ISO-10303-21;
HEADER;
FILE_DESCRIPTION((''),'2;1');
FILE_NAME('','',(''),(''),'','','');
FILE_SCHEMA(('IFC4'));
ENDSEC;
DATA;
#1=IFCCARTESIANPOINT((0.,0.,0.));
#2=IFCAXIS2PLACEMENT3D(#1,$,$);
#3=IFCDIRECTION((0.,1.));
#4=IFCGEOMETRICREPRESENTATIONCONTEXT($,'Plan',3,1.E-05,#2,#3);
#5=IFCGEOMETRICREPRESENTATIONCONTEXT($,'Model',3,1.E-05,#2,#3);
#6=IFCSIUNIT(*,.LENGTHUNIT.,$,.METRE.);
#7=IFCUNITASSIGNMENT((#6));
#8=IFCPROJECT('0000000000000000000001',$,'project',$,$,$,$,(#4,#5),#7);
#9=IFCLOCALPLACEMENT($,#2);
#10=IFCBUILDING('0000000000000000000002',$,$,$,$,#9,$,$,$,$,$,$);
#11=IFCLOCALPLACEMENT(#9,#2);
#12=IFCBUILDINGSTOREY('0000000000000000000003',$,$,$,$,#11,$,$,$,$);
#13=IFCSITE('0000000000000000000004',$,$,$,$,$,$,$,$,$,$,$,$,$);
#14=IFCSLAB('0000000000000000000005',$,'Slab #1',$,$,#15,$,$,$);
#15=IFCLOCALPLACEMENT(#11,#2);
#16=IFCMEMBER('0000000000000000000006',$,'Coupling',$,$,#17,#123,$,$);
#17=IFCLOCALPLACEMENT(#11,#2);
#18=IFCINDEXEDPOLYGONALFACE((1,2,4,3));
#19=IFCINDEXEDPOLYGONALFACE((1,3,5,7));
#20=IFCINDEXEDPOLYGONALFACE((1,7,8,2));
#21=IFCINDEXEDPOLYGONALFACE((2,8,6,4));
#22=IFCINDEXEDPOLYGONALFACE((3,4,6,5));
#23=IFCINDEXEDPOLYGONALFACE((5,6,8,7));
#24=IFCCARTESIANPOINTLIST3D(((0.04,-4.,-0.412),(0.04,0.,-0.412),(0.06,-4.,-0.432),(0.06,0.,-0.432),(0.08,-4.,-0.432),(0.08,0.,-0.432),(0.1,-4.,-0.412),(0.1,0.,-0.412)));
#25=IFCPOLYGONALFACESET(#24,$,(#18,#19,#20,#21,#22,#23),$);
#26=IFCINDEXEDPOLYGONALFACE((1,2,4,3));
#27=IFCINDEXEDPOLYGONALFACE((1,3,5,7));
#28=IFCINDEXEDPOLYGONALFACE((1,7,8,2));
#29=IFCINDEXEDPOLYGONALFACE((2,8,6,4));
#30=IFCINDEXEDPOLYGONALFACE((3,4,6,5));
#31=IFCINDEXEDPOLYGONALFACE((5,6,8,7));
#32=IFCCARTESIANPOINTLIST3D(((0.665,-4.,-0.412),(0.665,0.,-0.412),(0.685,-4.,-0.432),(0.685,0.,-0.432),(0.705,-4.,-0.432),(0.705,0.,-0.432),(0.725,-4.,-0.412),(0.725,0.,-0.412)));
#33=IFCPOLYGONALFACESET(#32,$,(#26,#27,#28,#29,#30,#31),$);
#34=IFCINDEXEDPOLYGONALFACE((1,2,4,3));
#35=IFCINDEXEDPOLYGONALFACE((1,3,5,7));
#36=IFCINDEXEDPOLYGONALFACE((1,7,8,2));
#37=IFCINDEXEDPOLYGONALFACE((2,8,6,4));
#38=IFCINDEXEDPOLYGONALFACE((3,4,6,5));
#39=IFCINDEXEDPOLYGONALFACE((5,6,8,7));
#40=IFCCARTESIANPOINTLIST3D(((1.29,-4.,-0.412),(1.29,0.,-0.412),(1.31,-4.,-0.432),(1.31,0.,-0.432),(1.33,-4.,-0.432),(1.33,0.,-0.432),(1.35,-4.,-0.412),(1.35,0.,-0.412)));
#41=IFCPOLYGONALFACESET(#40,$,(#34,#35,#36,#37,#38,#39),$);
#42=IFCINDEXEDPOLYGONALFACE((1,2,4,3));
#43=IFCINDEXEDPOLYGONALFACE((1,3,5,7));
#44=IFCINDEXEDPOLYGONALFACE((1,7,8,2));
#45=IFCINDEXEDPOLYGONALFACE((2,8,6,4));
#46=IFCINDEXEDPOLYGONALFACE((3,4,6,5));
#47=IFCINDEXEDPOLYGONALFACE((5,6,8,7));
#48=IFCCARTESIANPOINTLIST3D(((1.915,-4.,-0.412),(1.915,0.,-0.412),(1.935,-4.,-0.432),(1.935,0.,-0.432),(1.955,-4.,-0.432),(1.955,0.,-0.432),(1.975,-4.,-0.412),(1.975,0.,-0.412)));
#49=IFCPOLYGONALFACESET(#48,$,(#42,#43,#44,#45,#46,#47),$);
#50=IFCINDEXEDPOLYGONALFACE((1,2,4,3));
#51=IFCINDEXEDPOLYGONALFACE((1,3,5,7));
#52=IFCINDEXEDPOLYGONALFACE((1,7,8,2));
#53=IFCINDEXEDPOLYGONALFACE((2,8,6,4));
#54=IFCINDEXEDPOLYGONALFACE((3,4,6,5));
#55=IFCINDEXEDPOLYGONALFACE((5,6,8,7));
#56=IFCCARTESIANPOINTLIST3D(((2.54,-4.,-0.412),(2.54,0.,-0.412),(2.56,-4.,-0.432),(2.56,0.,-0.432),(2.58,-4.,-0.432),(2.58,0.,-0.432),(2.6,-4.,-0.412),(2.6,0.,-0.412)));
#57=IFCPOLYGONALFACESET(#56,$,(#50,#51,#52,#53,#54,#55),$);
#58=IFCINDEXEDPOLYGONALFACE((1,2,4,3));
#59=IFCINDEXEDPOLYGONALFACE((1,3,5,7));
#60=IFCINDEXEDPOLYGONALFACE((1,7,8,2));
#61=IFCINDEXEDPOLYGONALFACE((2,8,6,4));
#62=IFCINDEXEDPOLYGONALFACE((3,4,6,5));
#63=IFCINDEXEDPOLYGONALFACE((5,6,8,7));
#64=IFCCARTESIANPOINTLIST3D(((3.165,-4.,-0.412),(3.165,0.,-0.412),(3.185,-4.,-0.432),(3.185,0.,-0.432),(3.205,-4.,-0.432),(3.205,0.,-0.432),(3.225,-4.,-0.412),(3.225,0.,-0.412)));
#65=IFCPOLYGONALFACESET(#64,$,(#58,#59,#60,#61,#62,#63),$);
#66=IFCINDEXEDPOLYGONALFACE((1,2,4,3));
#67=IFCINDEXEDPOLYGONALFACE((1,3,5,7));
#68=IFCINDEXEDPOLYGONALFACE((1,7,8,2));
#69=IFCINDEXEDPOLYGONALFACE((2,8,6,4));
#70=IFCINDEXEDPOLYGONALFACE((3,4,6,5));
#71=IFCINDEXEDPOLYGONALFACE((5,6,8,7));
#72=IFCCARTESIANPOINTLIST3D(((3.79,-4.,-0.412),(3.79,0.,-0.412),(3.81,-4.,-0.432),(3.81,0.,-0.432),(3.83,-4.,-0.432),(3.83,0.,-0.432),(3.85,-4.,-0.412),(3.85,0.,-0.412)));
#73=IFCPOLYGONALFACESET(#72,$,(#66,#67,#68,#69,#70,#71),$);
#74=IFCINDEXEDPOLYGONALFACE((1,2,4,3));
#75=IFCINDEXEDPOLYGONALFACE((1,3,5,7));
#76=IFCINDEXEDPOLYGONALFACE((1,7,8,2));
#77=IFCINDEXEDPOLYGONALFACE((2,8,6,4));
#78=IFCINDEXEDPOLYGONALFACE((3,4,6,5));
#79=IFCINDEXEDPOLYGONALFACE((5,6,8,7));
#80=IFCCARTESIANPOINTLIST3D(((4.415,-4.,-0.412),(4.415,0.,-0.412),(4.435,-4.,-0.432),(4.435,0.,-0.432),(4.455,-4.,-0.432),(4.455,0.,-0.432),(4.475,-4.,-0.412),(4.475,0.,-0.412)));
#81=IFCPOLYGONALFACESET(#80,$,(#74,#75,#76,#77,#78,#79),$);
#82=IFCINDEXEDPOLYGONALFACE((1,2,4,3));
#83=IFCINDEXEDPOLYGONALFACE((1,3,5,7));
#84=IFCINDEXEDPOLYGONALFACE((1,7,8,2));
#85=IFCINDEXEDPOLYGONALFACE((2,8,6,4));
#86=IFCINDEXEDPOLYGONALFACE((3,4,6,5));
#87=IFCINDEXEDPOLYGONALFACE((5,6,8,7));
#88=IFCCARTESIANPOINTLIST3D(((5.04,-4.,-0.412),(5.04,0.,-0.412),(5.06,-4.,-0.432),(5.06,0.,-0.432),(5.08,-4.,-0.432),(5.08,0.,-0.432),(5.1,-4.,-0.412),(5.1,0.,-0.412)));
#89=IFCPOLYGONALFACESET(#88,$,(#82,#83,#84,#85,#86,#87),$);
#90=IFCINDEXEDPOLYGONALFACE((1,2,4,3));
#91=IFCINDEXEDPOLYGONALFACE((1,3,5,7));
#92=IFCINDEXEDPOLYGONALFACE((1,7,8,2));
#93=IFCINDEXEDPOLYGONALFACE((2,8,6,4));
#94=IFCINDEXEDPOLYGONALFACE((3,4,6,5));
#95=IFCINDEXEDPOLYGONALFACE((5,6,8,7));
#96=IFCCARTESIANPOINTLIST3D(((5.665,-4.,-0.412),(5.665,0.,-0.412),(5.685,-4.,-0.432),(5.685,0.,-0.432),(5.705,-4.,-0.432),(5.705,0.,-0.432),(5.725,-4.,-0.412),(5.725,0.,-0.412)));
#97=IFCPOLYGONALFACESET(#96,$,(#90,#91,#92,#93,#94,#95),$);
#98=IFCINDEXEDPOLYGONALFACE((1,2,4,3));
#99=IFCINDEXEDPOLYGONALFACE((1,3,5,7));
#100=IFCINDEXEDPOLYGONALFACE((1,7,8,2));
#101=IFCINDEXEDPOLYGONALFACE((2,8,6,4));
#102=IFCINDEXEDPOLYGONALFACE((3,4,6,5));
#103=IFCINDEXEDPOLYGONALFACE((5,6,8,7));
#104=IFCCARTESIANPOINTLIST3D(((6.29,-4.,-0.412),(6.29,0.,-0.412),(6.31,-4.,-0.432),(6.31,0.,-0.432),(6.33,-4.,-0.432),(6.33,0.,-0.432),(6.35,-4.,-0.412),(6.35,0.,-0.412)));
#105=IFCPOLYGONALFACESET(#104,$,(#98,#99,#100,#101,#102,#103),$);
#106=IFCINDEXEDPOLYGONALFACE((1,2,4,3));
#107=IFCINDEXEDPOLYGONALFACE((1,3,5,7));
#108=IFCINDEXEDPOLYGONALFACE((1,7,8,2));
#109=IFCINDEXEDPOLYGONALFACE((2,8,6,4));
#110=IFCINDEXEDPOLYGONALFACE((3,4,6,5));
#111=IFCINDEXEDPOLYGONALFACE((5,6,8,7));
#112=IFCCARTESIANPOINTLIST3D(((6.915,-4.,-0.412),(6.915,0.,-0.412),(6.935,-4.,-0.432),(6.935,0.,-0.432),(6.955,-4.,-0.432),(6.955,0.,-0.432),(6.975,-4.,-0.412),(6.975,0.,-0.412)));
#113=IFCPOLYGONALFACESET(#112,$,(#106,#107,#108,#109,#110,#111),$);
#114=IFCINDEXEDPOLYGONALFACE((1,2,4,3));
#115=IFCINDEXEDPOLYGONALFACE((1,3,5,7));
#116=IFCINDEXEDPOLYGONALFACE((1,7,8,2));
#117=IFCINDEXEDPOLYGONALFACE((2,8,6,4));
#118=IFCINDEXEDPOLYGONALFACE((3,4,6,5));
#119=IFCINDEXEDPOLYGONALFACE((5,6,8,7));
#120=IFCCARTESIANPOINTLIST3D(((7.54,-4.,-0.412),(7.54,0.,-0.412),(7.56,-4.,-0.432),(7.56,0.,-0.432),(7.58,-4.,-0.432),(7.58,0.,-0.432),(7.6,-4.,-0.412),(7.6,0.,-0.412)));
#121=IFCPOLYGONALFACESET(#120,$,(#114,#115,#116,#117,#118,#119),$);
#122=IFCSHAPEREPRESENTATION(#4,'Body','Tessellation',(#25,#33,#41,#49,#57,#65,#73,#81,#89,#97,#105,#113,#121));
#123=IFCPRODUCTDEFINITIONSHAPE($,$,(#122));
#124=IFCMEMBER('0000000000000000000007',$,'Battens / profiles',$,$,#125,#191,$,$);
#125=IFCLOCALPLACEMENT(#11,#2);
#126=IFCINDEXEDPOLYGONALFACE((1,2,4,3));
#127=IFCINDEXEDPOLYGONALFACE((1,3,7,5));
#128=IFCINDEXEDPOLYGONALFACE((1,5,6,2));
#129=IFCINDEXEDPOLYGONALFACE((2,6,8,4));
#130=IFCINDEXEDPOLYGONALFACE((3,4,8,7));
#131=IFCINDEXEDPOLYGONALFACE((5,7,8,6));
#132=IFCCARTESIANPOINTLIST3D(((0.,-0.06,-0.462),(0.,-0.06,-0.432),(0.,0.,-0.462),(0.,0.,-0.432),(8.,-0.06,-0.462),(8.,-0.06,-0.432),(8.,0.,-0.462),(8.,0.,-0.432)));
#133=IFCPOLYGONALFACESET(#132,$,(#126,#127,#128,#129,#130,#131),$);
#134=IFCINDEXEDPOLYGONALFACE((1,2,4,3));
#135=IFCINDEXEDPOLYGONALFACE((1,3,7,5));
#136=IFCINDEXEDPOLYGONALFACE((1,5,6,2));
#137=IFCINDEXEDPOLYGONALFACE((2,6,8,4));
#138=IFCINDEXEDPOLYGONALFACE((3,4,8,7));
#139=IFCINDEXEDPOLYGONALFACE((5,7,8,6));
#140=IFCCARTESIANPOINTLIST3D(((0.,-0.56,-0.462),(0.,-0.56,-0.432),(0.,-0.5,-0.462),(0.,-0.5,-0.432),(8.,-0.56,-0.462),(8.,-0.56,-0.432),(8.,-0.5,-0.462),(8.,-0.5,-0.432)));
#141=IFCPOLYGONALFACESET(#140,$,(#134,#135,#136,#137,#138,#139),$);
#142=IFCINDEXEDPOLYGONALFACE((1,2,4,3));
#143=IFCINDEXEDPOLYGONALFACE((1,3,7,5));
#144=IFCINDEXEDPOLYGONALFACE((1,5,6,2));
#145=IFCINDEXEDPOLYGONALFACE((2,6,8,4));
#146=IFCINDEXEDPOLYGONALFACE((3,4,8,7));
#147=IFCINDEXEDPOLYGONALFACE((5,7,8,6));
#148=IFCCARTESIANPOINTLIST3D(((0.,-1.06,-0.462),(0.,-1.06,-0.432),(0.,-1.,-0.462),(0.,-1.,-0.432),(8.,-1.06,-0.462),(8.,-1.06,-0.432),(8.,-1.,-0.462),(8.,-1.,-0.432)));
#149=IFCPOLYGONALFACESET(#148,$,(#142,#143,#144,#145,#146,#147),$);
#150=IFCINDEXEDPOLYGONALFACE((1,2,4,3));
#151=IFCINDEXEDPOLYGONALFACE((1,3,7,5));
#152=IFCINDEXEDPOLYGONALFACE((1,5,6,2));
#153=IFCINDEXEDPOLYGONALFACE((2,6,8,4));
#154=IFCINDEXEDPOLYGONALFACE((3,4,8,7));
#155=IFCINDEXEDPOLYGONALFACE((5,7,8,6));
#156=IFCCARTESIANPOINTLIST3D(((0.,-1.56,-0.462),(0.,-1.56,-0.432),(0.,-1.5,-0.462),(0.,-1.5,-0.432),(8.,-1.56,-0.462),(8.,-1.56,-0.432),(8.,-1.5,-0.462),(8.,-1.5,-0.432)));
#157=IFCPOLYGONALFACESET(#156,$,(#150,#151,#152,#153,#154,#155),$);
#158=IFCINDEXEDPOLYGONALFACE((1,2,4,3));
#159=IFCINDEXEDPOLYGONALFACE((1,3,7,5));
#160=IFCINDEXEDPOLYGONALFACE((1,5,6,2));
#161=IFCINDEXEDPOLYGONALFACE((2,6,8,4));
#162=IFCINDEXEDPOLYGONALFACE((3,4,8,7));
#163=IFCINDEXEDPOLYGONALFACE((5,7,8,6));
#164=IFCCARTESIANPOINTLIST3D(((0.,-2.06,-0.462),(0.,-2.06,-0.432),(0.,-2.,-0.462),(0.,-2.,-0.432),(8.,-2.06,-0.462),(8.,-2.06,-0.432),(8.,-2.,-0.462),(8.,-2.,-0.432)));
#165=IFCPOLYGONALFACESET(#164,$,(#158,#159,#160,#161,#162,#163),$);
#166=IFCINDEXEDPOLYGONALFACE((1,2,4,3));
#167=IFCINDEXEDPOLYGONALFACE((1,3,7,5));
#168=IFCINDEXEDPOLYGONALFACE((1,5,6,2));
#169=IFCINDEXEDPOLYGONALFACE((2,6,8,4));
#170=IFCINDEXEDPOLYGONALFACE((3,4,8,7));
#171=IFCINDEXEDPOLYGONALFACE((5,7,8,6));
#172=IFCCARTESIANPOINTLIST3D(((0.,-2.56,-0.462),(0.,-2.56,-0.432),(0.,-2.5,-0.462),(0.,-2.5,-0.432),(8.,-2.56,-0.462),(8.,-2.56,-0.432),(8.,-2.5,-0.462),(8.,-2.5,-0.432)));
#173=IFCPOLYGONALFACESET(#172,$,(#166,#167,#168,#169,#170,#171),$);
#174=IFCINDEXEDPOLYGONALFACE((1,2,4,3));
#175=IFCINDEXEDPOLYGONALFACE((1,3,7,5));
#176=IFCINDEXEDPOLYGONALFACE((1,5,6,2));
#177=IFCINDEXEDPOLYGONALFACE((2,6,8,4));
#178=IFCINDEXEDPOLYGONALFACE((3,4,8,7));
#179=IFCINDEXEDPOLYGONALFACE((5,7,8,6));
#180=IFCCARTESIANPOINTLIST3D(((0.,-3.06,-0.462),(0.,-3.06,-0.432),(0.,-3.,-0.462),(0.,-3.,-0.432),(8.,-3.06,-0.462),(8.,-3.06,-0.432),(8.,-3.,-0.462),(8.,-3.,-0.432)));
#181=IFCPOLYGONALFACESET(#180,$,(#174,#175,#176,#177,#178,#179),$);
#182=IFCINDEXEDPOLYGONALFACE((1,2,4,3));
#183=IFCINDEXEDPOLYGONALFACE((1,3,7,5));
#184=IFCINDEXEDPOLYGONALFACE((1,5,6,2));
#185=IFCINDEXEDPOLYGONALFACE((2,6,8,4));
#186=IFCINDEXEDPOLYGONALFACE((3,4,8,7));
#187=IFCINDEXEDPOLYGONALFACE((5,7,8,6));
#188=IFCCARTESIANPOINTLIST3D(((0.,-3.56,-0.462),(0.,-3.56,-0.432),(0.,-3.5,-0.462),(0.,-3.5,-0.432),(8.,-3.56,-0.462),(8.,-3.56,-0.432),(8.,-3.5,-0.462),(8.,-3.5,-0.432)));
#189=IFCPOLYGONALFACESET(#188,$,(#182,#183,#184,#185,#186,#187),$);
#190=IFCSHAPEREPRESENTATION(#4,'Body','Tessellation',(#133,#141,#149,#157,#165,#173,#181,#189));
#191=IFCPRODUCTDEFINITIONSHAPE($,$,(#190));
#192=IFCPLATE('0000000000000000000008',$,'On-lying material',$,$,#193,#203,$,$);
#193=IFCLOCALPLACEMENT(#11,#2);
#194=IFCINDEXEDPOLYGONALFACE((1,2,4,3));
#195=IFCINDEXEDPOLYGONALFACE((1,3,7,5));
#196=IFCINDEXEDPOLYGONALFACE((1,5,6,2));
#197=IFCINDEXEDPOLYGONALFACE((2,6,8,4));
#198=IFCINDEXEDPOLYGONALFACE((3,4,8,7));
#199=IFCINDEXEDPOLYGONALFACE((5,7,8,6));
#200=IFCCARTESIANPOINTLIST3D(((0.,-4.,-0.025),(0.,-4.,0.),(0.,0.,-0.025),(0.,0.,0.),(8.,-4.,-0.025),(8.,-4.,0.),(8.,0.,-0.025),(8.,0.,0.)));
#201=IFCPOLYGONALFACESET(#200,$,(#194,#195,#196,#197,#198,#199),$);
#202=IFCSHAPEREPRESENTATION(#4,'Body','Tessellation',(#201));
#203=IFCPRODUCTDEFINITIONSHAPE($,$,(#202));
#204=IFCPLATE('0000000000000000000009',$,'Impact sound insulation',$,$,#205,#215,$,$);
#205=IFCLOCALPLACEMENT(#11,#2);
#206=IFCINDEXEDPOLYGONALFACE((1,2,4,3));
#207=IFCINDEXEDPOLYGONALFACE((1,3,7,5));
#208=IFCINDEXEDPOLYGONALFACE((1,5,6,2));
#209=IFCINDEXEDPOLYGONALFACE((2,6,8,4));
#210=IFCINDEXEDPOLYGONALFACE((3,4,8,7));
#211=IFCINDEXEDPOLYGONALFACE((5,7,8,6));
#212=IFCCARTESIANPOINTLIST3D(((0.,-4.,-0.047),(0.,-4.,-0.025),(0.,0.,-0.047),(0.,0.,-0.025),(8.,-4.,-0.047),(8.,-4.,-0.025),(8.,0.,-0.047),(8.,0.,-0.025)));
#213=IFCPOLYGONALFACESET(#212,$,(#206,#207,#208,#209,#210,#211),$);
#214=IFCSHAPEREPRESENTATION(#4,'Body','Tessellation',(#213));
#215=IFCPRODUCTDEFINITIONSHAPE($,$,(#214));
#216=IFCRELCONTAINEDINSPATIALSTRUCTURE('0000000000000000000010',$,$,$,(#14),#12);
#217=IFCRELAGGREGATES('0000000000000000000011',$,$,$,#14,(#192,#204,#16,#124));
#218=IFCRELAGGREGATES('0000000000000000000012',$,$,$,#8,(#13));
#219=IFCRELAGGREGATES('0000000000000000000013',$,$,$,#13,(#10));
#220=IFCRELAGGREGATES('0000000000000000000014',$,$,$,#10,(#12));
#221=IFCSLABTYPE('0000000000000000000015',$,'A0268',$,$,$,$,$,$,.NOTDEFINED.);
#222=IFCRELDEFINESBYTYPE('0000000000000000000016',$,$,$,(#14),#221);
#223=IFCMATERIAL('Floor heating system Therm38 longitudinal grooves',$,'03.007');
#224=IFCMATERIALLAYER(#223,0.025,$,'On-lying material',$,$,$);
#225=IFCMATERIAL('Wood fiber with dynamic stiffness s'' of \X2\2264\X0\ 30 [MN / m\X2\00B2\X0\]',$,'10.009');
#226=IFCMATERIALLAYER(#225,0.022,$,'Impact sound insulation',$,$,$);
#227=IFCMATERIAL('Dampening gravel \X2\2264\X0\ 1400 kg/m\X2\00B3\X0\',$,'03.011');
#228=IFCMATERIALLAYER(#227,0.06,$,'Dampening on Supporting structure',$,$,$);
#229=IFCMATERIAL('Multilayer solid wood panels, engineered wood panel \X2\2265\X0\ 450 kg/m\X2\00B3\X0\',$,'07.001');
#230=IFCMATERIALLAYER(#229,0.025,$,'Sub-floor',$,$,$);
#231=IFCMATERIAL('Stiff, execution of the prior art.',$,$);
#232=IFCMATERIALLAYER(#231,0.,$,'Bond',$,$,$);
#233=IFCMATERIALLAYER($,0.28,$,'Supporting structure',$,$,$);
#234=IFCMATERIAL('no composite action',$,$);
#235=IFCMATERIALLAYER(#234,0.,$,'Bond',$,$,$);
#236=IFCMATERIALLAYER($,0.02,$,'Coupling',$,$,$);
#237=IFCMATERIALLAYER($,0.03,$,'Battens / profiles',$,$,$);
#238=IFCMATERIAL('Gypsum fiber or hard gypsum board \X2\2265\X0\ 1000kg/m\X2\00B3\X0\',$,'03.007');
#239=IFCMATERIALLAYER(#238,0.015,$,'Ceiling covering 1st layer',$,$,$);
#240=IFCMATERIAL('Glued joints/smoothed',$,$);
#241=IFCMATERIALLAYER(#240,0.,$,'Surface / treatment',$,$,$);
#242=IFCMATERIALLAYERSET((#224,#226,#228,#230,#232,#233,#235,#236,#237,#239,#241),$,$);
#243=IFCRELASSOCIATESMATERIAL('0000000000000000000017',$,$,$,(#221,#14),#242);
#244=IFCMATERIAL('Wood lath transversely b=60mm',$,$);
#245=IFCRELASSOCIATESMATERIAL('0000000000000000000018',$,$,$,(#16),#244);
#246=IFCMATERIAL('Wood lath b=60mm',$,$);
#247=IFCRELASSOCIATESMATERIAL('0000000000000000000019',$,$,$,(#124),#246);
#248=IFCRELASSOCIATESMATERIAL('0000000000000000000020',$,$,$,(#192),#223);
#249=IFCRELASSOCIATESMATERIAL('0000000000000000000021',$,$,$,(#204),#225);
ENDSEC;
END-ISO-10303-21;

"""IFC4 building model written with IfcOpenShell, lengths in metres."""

from ifc_helpers import new_model, si_unit, direction, frame, frame_2d, origin, origin_with_axes, place, context, project, spatial, polyline, rectangle, outline, extrude, material, layer, layer_set, type_object, element, aggregate, save


model = new_model("IFC4")

# Units and contexts
plan_context = context("Plan", 3, precision=1e-05, world=origin(), true_north=direction((0.0, 1.0)))
model_context = context("Model", 3, precision=1e-05, world=origin(), true_north=direction((0.0, 1.0)))
ifc_project = project(units=[si_unit("LENGTHUNIT", "METRE")], contexts=[plan_context, model_context])

# Site, building, storey
site = spatial("IfcSite", under=ifc_project)
building_placement = place(None, origin())
building = spatial("IfcBuilding", under=site, at=building_placement)
storey_placement = place(building_placement, origin())
storey = spatial("IfcBuildingStorey", under=building, at=storey_placement)

# Slab, members, plates
ifc_material_1 = material(Name="Floor heating system Therm38 longitudinal grooves", Category="03.007")
ifc_layer_1 = layer(ifc_material_1, 0.025, Name="On-lying material")
ifc_material_2 = material(Name="Wood fiber with dynamic stiffness s' of ≤ 30 [MN / m²]", Category="10.009")
ifc_layer_2 = layer(ifc_material_2, 0.022, Name="Impact sound insulation")
ifc_material_3 = material(Name="Dampening gravel ≤ 1400 kg/m³", Category="03.011")
ifc_layer_3 = layer(ifc_material_3, 0.06, Name="Dampening on Supporting structure")
ifc_material_4 = material(Name="Multilayer solid wood panels, engineered wood panel ≥ 450 kg/m³", Category="07.001")
ifc_layer_4 = layer(ifc_material_4, 0.025, Name="Sub-floor")
ifc_material_5 = material(Name="Stiff, execution of the prior art.")
ifc_layer_5 = layer(ifc_material_5, 0.0, Name="Bond")
ifc_layer_6 = layer(None, 0.28, Name="Supporting structure")
ifc_material_6 = material(Name="no composite action")
ifc_layer_7 = layer(ifc_material_6, 0.0, Name="Bond")
ifc_layer_8 = layer(None, 0.02, Name="Coupling")
ifc_layer_9 = layer(None, 0.03, Name="Battens / profiles")
ifc_material_7 = material(Name="Gypsum fiber or hard gypsum board ≥ 1000kg/m³", Category="03.007")
ifc_layer_10 = layer(ifc_material_7, 0.015, Name="Ceiling covering 1st layer")
ifc_material_8 = material(Name="Glued joints/smoothed")
ifc_layer_11 = layer(ifc_material_8, 0.0, Name="Surface / treatment")
ifc_layer_set = layer_set([ifc_layer_1, ifc_layer_2, ifc_layer_3, ifc_layer_4, ifc_layer_5, ifc_layer_6, ifc_layer_7, ifc_layer_8, ifc_layer_9, ifc_layer_10, ifc_layer_11])
slab_type = type_object("IfcSlabType", Name="A0268", PredefinedType="NOTDEFINED", material=ifc_layer_set)
slab_placement = place(None, frame((0.0, 0.0, 0.0), z_axis=(0.0, 0.0, -1.0), x_axis=(1.0, 0.0, 0.0)))
slab = element("IfcSlab", 1, at=slab_placement, inside=storey, type_object=slab_type, material=ifc_layer_set, Name="Slab #1")
ifc_material_9 = material(Name="Wood lath transversely b=60mm")
member_1_placement = place(slab_placement, origin())
member_1 = element("IfcMember", 2, at=member_1_placement, material=ifc_material_9, Name="Coupling", context=plan_context, shape_type="SweptSolid", body=[
    extrude(outline(polyline([(0.0, 0.0), (0.06, 0.0), (0.04, 0.02), (0.02, 0.02), (0.0, 0.0)])), frame((0.04, 4.0, 0.412), z_axis=(0.0, -1.0, 0.0), x_axis=(1.0, 0.0, 0.0)), (0.0, 0.0, 1.0), 4.0),
    extrude(outline(polyline([(0.0, 0.0), (0.06, 0.0), (0.04, 0.02), (0.02, 0.02), (0.0, 0.0)])), frame((0.665, 4.0, 0.412), z_axis=(0.0, -1.0, 0.0), x_axis=(1.0, 0.0, 0.0)), (0.0, 0.0, 1.0), 4.0),
    extrude(outline(polyline([(0.0, 0.0), (0.06, 0.0), (0.04, 0.02), (0.02, 0.02), (0.0, 0.0)])), frame((1.29, 4.0, 0.412), z_axis=(0.0, -1.0, 0.0), x_axis=(1.0, 0.0, 0.0)), (0.0, 0.0, 1.0), 4.0),
    extrude(outline(polyline([(0.0, 0.0), (0.06, 0.0), (0.04, 0.02), (0.02, 0.02), (0.0, 0.0)])), frame((1.915, 4.0, 0.412), z_axis=(0.0, -1.0, 0.0), x_axis=(1.0, 0.0, 0.0)), (0.0, 0.0, 1.0), 4.0),
    extrude(outline(polyline([(0.0, 0.0), (0.06, 0.0), (0.04, 0.02), (0.02, 0.02), (0.0, 0.0)])), frame((2.54, 4.0, 0.412), z_axis=(0.0, -1.0, 0.0), x_axis=(1.0, 0.0, 0.0)), (0.0, 0.0, 1.0), 4.0),
    extrude(outline(polyline([(0.0, 0.0), (0.06, 0.0), (0.04, 0.02), (0.02, 0.02), (0.0, 0.0)])), frame((3.165, 4.0, 0.412), z_axis=(0.0, -1.0, 0.0), x_axis=(1.0, 0.0, 0.0)), (0.0, 0.0, 1.0), 4.0),
    extrude(outline(polyline([(0.0, 0.0), (0.06, 0.0), (0.04, 0.02), (0.02, 0.02), (0.0, 0.0)])), frame((3.79, 4.0, 0.412), z_axis=(0.0, -1.0, 0.0), x_axis=(1.0, 0.0, 0.0)), (0.0, 0.0, 1.0), 4.0),
    extrude(outline(polyline([(0.0, 0.0), (0.06, 0.0), (0.04, 0.02), (0.02, 0.02), (0.0, 0.0)])), frame((4.415, 4.0, 0.412), z_axis=(0.0, -1.0, 0.0), x_axis=(1.0, 0.0, 0.0)), (0.0, 0.0, 1.0), 4.0),
    extrude(outline(polyline([(0.0, 0.0), (0.06, 0.0), (0.04, 0.02), (0.02, 0.02), (0.0, 0.0)])), frame((5.04, 4.0, 0.412), z_axis=(0.0, -1.0, 0.0), x_axis=(1.0, 0.0, 0.0)), (0.0, 0.0, 1.0), 4.0),
    extrude(outline(polyline([(0.0, 0.0), (0.06, 0.0), (0.04, 0.02), (0.02, 0.02), (0.0, 0.0)])), frame((5.665, 4.0, 0.412), z_axis=(0.0, -1.0, 0.0), x_axis=(1.0, 0.0, 0.0)), (0.0, 0.0, 1.0), 4.0),
    extrude(outline(polyline([(0.0, 0.0), (0.06, 0.0), (0.04, 0.02), (0.02, 0.02), (0.0, 0.0)])), frame((6.29, 4.0, 0.412), z_axis=(0.0, -1.0, 0.0), x_axis=(1.0, 0.0, 0.0)), (0.0, 0.0, 1.0), 4.0),
    extrude(outline(polyline([(0.0, 0.0), (0.06, 0.0), (0.04, 0.02), (0.02, 0.02), (0.0, 0.0)])), frame((6.915, 4.0, 0.412), z_axis=(0.0, -1.0, 0.0), x_axis=(1.0, 0.0, 0.0)), (0.0, 0.0, 1.0), 4.0),
    extrude(outline(polyline([(0.0, 0.0), (0.06, 0.0), (0.04, 0.02), (0.02, 0.02), (0.0, 0.0)])), frame((7.54, 4.0, 0.412), z_axis=(0.0, -1.0, 0.0), x_axis=(1.0, 0.0, 0.0)), (0.0, 0.0, 1.0), 4.0),
])
ifc_material_10 = material(Name="Wood lath b=60mm")
member_2_placement = place(slab_placement, origin())
member_2 = element("IfcMember", 3, at=member_2_placement, material=ifc_material_10, Name="Battens / profiles", context=plan_context, shape_type="SweptSolid", body=[
    extrude(rectangle(XDim=0.06, YDim=0.03, at=frame_2d((0.03, 0.015), x_axis=(1.0, 0.0))), frame((0.0, 0.0, 0.432), z_axis=(1.0, 0.0, 0.0), x_axis=(0.0, 1.0, 0.0)), (0.0, 0.0, 1.0), 8.0),
    extrude(rectangle(XDim=0.06, YDim=0.03, at=frame_2d((0.03, 0.015), x_axis=(1.0, 0.0))), frame((0.0, 0.5, 0.432), z_axis=(1.0, 0.0, 0.0), x_axis=(0.0, 1.0, 0.0)), (0.0, 0.0, 1.0), 8.0),
    extrude(rectangle(XDim=0.06, YDim=0.03, at=frame_2d((0.03, 0.015), x_axis=(1.0, 0.0))), frame((0.0, 1.0, 0.432), z_axis=(1.0, 0.0, 0.0), x_axis=(0.0, 1.0, 0.0)), (0.0, 0.0, 1.0), 8.0),
    extrude(rectangle(XDim=0.06, YDim=0.03, at=frame_2d((0.03, 0.015), x_axis=(1.0, 0.0))), frame((0.0, 1.5, 0.432), z_axis=(1.0, 0.0, 0.0), x_axis=(0.0, 1.0, 0.0)), (0.0, 0.0, 1.0), 8.0),
    extrude(rectangle(XDim=0.06, YDim=0.03, at=frame_2d((0.03, 0.015), x_axis=(1.0, 0.0))), frame((0.0, 2.0, 0.432), z_axis=(1.0, 0.0, 0.0), x_axis=(0.0, 1.0, 0.0)), (0.0, 0.0, 1.0), 8.0),
    extrude(rectangle(XDim=0.06, YDim=0.03, at=frame_2d((0.03, 0.015), x_axis=(1.0, 0.0))), frame((0.0, 2.5, 0.432), z_axis=(1.0, 0.0, 0.0), x_axis=(0.0, 1.0, 0.0)), (0.0, 0.0, 1.0), 8.0),
    extrude(rectangle(XDim=0.06, YDim=0.03, at=frame_2d((0.03, 0.015), x_axis=(1.0, 0.0))), frame((0.0, 3.0, 0.432), z_axis=(1.0, 0.0, 0.0), x_axis=(0.0, 1.0, 0.0)), (0.0, 0.0, 1.0), 8.0),
    extrude(rectangle(XDim=0.06, YDim=0.03, at=frame_2d((0.03, 0.015), x_axis=(1.0, 0.0))), frame((0.0, 3.5, 0.432), z_axis=(1.0, 0.0, 0.0), x_axis=(0.0, 1.0, 0.0)), (0.0, 0.0, 1.0), 8.0),
])
plate_1_placement = place(slab_placement, origin())
plate_1 = element("IfcPlate", 4, at=plate_1_placement, material=ifc_material_1, Name="On-lying material", context=plan_context, shape_type="SweptSolid", body=[
    extrude(rectangle(XDim=8.0, YDim=4.0, at=frame_2d((4.0, 2.0), x_axis=(1.0, 0.0))), origin_with_axes(), (0.0, 0.0, 1.0), 0.025),
])
plate_2_placement = place(slab_placement, origin())
plate_2 = element("IfcPlate", 5, at=plate_2_placement, material=ifc_material_2, Name="Impact sound insulation", context=plan_context, shape_type="SweptSolid", body=[
    extrude(rectangle(XDim=8.0, YDim=4.0, at=frame_2d((4.0, 2.0), x_axis=(1.0, 0.0))), frame((0.0, 0.0, 0.025), z_axis=(0.0, 0.0, 1.0), x_axis=(1.0, 0.0, 0.0)), (0.0, 0.0, 1.0), 0.022),
])
aggregate(slab, [plate_1, plate_2, member_1, member_2])

save(model, "model.ifc")
